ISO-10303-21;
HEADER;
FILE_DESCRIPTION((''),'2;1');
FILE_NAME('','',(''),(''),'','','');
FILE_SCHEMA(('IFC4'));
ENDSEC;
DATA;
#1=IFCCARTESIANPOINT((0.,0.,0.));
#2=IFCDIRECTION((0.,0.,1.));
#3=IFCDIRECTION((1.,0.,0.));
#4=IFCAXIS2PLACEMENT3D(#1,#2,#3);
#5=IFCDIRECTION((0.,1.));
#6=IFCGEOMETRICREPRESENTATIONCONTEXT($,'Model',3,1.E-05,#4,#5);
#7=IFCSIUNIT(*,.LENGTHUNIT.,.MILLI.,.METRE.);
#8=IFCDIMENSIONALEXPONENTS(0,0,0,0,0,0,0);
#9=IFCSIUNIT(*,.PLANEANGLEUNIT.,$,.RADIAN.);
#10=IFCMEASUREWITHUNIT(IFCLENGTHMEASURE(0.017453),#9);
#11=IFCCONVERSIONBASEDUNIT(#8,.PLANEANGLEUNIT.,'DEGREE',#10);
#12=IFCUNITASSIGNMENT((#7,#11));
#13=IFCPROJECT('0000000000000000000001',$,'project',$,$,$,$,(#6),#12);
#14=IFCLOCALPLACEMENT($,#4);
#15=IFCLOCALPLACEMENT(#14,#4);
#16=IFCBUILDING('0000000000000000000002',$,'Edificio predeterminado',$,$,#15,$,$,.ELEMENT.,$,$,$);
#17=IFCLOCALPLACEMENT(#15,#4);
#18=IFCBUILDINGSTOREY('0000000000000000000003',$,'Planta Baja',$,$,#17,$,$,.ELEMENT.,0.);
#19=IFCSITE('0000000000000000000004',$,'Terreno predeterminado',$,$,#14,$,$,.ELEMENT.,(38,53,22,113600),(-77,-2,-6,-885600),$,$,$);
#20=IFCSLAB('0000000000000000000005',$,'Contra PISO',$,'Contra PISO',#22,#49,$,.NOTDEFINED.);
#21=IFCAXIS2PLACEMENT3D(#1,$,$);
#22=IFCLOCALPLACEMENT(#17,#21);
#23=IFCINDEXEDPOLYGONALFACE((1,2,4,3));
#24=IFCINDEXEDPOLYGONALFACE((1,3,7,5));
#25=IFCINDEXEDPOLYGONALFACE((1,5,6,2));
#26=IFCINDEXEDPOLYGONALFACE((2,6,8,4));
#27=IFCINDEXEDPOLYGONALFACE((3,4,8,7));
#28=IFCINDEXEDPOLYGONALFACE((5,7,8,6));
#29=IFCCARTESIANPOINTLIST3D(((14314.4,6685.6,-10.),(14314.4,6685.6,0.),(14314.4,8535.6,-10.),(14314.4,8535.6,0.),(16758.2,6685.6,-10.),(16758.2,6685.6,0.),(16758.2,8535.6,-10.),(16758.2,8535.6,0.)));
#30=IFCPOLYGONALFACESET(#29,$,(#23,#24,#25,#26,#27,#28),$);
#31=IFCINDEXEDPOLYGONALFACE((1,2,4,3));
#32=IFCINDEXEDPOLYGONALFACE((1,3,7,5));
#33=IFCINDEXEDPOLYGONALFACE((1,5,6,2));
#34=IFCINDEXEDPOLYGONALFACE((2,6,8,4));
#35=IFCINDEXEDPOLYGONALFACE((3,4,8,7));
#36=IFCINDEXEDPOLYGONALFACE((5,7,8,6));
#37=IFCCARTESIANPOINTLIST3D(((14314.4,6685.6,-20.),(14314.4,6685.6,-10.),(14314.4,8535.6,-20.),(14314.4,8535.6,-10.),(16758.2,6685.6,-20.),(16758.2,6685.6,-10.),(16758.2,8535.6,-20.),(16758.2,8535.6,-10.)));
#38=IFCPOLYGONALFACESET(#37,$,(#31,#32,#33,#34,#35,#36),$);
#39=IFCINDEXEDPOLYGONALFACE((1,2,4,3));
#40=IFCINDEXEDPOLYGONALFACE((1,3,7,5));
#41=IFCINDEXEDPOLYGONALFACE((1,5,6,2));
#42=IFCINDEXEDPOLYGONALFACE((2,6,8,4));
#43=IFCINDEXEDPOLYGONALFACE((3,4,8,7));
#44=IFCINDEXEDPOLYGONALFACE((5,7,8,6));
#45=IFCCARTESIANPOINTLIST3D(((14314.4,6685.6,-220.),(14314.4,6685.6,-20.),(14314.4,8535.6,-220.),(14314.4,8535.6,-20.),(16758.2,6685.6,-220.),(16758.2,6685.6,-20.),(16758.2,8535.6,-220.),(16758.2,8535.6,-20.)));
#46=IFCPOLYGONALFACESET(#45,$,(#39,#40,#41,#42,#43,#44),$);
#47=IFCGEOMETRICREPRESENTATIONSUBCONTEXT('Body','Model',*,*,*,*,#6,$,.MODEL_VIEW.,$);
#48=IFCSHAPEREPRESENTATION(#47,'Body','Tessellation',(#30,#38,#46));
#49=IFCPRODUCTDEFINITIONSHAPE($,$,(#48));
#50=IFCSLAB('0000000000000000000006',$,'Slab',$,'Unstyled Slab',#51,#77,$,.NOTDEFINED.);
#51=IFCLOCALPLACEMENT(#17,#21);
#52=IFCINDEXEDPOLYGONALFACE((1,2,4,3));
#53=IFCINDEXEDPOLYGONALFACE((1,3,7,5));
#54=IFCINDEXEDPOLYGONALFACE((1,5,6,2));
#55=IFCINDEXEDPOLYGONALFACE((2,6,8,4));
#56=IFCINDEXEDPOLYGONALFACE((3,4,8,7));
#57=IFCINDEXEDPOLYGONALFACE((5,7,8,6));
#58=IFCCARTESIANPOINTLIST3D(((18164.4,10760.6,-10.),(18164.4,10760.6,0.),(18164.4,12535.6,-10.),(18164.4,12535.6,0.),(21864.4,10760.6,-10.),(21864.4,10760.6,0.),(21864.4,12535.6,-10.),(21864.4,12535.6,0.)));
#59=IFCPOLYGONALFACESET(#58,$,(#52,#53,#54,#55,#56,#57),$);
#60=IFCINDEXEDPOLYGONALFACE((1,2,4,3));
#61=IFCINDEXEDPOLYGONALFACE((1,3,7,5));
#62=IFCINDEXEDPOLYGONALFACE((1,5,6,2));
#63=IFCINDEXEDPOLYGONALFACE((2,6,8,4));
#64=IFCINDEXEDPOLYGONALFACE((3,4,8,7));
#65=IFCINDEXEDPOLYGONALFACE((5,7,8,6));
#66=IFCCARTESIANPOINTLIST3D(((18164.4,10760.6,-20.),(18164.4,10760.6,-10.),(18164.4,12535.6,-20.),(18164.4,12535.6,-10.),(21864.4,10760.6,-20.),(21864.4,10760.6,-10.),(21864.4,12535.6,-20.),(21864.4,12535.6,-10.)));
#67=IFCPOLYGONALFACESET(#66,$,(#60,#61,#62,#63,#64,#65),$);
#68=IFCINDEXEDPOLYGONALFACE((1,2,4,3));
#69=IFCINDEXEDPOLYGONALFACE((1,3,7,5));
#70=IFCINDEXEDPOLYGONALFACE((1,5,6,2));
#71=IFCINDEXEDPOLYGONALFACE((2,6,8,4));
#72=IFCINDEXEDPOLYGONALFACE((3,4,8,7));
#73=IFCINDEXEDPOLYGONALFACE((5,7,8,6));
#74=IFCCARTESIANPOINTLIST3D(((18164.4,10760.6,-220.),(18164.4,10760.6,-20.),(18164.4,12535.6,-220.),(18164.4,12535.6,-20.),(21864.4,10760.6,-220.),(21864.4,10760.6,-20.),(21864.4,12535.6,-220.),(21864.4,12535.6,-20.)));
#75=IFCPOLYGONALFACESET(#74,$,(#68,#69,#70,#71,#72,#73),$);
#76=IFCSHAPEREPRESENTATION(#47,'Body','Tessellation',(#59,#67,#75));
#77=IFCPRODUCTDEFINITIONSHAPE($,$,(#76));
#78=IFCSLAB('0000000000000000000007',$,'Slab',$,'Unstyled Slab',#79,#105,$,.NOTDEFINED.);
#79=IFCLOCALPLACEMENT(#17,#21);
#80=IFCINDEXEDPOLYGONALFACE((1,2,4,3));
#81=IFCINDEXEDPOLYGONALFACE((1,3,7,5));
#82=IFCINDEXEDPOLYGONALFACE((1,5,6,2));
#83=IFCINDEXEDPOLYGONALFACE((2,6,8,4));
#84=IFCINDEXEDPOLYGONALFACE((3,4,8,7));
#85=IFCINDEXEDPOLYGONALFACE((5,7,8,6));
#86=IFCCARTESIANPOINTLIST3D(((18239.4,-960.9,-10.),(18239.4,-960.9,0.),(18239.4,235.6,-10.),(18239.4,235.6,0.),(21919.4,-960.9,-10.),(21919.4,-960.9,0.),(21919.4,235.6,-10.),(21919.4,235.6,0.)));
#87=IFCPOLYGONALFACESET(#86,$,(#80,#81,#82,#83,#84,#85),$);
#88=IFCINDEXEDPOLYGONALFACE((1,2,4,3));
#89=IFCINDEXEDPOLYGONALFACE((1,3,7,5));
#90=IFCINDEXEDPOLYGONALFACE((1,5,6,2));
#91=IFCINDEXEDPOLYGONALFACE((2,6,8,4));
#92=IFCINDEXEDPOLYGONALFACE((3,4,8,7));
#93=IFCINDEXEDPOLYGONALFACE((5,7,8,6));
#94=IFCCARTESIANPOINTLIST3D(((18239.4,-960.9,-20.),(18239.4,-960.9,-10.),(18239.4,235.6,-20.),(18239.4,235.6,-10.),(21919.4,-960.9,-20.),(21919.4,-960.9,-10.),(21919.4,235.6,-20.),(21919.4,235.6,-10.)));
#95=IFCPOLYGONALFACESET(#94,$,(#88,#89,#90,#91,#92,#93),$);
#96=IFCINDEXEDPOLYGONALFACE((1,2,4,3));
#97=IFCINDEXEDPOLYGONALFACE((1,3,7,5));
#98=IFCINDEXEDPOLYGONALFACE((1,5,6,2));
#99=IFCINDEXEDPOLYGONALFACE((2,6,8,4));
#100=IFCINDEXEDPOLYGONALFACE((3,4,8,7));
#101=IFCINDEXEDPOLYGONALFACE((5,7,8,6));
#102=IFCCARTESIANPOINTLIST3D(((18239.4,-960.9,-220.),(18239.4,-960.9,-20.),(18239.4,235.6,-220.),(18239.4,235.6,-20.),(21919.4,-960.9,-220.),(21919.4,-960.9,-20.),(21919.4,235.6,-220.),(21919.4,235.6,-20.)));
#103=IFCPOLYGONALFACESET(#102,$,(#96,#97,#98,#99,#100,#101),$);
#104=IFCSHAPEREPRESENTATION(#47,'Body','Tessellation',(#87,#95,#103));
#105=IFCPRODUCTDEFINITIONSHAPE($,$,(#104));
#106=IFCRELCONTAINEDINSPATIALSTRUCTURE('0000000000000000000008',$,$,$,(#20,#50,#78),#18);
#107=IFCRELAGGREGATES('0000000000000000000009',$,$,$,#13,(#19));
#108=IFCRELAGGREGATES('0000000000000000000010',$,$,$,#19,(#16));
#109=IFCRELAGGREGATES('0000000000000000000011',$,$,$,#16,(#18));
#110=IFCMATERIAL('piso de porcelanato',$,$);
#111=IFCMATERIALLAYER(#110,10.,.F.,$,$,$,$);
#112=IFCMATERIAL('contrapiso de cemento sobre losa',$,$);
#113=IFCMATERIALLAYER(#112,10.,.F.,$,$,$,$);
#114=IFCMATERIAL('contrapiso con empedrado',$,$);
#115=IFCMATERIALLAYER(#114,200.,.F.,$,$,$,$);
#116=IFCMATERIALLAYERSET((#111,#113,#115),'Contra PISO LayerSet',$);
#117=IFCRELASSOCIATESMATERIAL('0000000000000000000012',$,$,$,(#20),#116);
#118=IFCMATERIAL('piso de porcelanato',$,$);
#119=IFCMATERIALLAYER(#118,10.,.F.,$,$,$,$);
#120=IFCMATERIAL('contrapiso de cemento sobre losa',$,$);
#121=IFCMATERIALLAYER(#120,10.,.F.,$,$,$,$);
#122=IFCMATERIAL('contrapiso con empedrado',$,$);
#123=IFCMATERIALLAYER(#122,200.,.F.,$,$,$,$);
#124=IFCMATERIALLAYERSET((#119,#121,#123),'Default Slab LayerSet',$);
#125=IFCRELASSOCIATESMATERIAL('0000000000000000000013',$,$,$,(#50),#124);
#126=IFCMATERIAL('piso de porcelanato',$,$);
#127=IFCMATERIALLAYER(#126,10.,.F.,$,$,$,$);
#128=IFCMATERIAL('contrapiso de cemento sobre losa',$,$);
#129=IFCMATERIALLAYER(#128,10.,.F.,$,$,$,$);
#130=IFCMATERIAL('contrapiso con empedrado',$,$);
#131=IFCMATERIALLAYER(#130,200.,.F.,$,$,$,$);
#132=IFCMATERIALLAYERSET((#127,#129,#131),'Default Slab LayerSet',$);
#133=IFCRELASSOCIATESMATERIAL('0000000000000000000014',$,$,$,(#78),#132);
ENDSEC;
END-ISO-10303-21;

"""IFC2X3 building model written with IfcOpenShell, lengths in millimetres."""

from ifc_helpers import new_model, entity, si_unit, converted_unit, direction, frame, origin_with_axes, place, context, subcontext, project, spatial, polyline, outline, extrude, material, layer, layer_set, layer_usage, element, save


model = new_model("IFC2X3")

# Units and contexts
model_context = context("Model", 3, precision=1e-05, world=origin_with_axes(), true_north=direction((0.0, 1.0)))
body_context = subcontext(model_context, "Body", "Model", "MODEL_VIEW")
ifc_project = project(units=[si_unit("LENGTHUNIT", "METRE", prefix="MILLI"), converted_unit("PLANEANGLEUNIT", "DEGREE", entity("IfcLengthMeasure", 0.017453), si_unit("PLANEANGLEUNIT", "RADIAN"), dimensions=[0, 0, 0, 0, 0, 0, 0])], contexts=[model_context])

# Site, building, storey
site_placement = place(None, origin_with_axes())
site = spatial("IfcSite", under=ifc_project, at=site_placement, Name="Terreno predeterminado", CompositionType="ELEMENT", RefLatitude=(38, 53, 22, 113600), RefLongitude=(-77, -2, -6, -885600))
building_placement = place(site_placement, origin_with_axes())
building = spatial("IfcBuilding", under=site, at=building_placement, Name="Edificio predeterminado", CompositionType="ELEMENT")
storey_placement = place(building_placement, origin_with_axes())
storey = spatial("IfcBuildingStorey", under=building, at=storey_placement, Name="Planta Baja", CompositionType="ELEMENT", Elevation=0.0)

# Slabs
ifc_material_1 = material(Name="piso de porcelanato")
ifc_layer_1 = layer(ifc_material_1, 10.0, ventilated=False)
ifc_material_2 = material(Name="contrapiso de cemento sobre losa")
ifc_layer_2 = layer(ifc_material_2, 10.0, ventilated=False)
ifc_material_3 = material(Name="contrapiso con empedrado")
ifc_layer_3 = layer(ifc_material_3, 200.0, ventilated=False)
ifc_layer_set_1 = layer_set([ifc_layer_1, ifc_layer_2, ifc_layer_3], Name="Contra PISO LayerSet")
ifc_layer_usage_1 = layer_usage(ifc_layer_set_1, "AXIS3", "NEGATIVE", 0.0)
slab_1_placement = place(storey_placement, origin_with_axes())
element("IfcSlab", 1, at=slab_1_placement, inside=storey, material=ifc_layer_usage_1, Name="Contra PISO", ObjectType="Contra PISO", PredefinedType="NOTDEFINED", context=body_context, shape_type="SweptSolid", body=[
    extrude(outline(polyline([(0.0, 2443.9), (1850.0, 2443.9), (1850.0, 0.0), (0.0, 0.0), (0.0, 2443.9)])), frame((14314.4, 6685.6, -10.0), z_axis=(0.0, 0.0, -1.0), x_axis=(0.0, 1.0, 0.0)), (0.0, 0.0, -1.0), 10.0),
    extrude(outline(polyline([(0.0, 2443.9), (1850.0, 2443.9), (1850.0, 0.0), (0.0, 0.0), (0.0, 2443.9)])), frame((14314.4, 6685.6, -20.0), z_axis=(0.0, 0.0, -1.0), x_axis=(0.0, 1.0, 0.0)), (0.0, 0.0, -1.0), 10.0),
    extrude(outline(polyline([(0.0, 2443.9), (1850.0, 2443.9), (1850.0, 0.0), (0.0, 0.0), (0.0, 2443.9)])), frame((14314.4, 6685.6, -220.0), z_axis=(0.0, 0.0, -1.0), x_axis=(0.0, 1.0, 0.0)), (0.0, 0.0, -1.0), 200.0),
])
ifc_material_4 = material(Name="piso de porcelanato")
ifc_layer_4 = layer(ifc_material_4, 10.0, ventilated=False)
ifc_material_5 = material(Name="contrapiso de cemento sobre losa")
ifc_layer_5 = layer(ifc_material_5, 10.0, ventilated=False)
ifc_material_6 = material(Name="contrapiso con empedrado")
ifc_layer_6 = layer(ifc_material_6, 200.0, ventilated=False)
ifc_layer_set_2 = layer_set([ifc_layer_4, ifc_layer_5, ifc_layer_6], Name="Default Slab LayerSet")
ifc_layer_usage_2 = layer_usage(ifc_layer_set_2, "AXIS3", "POSITIVE", 0.0)
slab_2_placement = place(storey_placement, origin_with_axes())
element("IfcSlab", 2, at=slab_2_placement, inside=storey, material=ifc_layer_usage_2, Name="Slab", ObjectType="Unstyled Slab", PredefinedType="NOTDEFINED", context=body_context, shape_type="SweptSolid", body=[
    extrude(outline(polyline([(0.0, 0.0), (1775.0, 0.0), (1775.0, 3700.0), (0.0, 3700.0), (0.0, 0.0)])), frame((21864.4, 12535.6, -10.0), z_axis=(0.0, 0.0, -1.0), x_axis=(0.0, -1.0, 0.0)), (0.0, 0.0, -1.0), 10.0),
    extrude(outline(polyline([(0.0, 0.0), (1775.0, 0.0), (1775.0, 3700.0), (0.0, 3700.0), (0.0, 0.0)])), frame((21864.4, 12535.6, -20.0), z_axis=(0.0, 0.0, -1.0), x_axis=(0.0, -1.0, 0.0)), (0.0, 0.0, -1.0), 10.0),
    extrude(outline(polyline([(0.0, 0.0), (1775.0, 0.0), (1775.0, 3700.0), (0.0, 3700.0), (0.0, 0.0)])), frame((21864.4, 12535.6, -220.0), z_axis=(0.0, 0.0, -1.0), x_axis=(0.0, -1.0, 0.0)), (0.0, 0.0, -1.0), 200.0),
])
ifc_material_7 = material(Name="piso de porcelanato")
ifc_layer_7 = layer(ifc_material_7, 10.0, ventilated=False)
ifc_material_8 = material(Name="contrapiso de cemento sobre losa")
ifc_layer_8 = layer(ifc_material_8, 10.0, ventilated=False)
ifc_material_9 = material(Name="contrapiso con empedrado")
ifc_layer_9 = layer(ifc_material_9, 200.0, ventilated=False)
ifc_layer_set_3 = layer_set([ifc_layer_7, ifc_layer_8, ifc_layer_9], Name="Default Slab LayerSet")
ifc_layer_usage_3 = layer_usage(ifc_layer_set_3, "AXIS3", "POSITIVE", 0.0)
slab_3_placement = place(storey_placement, origin_with_axes())
element("IfcSlab", 3, at=slab_3_placement, inside=storey, material=ifc_layer_usage_3, Name="Slab", ObjectType="Unstyled Slab", PredefinedType="NOTDEFINED", context=body_context, shape_type="SweptSolid", body=[
    extrude(outline(polyline([(0.0, 0.0), (1196.6, 0.0), (1196.6, 3680.0), (0.0, 3680.0), (0.0, 0.0)])), frame((21919.4, 235.6, -10.0), z_axis=(0.0, 0.0, -1.0), x_axis=(0.0, -1.0, 0.0)), (0.0, 0.0, -1.0), 10.0),
    extrude(outline(polyline([(0.0, 0.0), (1196.6, 0.0), (1196.6, 3680.0), (0.0, 3680.0), (0.0, 0.0)])), frame((21919.4, 235.6, -20.0), z_axis=(0.0, 0.0, -1.0), x_axis=(0.0, -1.0, 0.0)), (0.0, 0.0, -1.0), 10.0),
    extrude(outline(polyline([(0.0, 0.0), (1196.6, 0.0), (1196.6, 3680.0), (0.0, 3680.0), (0.0, 0.0)])), frame((21919.4, 235.6, -220.0), z_axis=(0.0, 0.0, -1.0), x_axis=(0.0, -1.0, 0.0)), (0.0, 0.0, -1.0), 200.0),
])

save(model, "model.ifc")
